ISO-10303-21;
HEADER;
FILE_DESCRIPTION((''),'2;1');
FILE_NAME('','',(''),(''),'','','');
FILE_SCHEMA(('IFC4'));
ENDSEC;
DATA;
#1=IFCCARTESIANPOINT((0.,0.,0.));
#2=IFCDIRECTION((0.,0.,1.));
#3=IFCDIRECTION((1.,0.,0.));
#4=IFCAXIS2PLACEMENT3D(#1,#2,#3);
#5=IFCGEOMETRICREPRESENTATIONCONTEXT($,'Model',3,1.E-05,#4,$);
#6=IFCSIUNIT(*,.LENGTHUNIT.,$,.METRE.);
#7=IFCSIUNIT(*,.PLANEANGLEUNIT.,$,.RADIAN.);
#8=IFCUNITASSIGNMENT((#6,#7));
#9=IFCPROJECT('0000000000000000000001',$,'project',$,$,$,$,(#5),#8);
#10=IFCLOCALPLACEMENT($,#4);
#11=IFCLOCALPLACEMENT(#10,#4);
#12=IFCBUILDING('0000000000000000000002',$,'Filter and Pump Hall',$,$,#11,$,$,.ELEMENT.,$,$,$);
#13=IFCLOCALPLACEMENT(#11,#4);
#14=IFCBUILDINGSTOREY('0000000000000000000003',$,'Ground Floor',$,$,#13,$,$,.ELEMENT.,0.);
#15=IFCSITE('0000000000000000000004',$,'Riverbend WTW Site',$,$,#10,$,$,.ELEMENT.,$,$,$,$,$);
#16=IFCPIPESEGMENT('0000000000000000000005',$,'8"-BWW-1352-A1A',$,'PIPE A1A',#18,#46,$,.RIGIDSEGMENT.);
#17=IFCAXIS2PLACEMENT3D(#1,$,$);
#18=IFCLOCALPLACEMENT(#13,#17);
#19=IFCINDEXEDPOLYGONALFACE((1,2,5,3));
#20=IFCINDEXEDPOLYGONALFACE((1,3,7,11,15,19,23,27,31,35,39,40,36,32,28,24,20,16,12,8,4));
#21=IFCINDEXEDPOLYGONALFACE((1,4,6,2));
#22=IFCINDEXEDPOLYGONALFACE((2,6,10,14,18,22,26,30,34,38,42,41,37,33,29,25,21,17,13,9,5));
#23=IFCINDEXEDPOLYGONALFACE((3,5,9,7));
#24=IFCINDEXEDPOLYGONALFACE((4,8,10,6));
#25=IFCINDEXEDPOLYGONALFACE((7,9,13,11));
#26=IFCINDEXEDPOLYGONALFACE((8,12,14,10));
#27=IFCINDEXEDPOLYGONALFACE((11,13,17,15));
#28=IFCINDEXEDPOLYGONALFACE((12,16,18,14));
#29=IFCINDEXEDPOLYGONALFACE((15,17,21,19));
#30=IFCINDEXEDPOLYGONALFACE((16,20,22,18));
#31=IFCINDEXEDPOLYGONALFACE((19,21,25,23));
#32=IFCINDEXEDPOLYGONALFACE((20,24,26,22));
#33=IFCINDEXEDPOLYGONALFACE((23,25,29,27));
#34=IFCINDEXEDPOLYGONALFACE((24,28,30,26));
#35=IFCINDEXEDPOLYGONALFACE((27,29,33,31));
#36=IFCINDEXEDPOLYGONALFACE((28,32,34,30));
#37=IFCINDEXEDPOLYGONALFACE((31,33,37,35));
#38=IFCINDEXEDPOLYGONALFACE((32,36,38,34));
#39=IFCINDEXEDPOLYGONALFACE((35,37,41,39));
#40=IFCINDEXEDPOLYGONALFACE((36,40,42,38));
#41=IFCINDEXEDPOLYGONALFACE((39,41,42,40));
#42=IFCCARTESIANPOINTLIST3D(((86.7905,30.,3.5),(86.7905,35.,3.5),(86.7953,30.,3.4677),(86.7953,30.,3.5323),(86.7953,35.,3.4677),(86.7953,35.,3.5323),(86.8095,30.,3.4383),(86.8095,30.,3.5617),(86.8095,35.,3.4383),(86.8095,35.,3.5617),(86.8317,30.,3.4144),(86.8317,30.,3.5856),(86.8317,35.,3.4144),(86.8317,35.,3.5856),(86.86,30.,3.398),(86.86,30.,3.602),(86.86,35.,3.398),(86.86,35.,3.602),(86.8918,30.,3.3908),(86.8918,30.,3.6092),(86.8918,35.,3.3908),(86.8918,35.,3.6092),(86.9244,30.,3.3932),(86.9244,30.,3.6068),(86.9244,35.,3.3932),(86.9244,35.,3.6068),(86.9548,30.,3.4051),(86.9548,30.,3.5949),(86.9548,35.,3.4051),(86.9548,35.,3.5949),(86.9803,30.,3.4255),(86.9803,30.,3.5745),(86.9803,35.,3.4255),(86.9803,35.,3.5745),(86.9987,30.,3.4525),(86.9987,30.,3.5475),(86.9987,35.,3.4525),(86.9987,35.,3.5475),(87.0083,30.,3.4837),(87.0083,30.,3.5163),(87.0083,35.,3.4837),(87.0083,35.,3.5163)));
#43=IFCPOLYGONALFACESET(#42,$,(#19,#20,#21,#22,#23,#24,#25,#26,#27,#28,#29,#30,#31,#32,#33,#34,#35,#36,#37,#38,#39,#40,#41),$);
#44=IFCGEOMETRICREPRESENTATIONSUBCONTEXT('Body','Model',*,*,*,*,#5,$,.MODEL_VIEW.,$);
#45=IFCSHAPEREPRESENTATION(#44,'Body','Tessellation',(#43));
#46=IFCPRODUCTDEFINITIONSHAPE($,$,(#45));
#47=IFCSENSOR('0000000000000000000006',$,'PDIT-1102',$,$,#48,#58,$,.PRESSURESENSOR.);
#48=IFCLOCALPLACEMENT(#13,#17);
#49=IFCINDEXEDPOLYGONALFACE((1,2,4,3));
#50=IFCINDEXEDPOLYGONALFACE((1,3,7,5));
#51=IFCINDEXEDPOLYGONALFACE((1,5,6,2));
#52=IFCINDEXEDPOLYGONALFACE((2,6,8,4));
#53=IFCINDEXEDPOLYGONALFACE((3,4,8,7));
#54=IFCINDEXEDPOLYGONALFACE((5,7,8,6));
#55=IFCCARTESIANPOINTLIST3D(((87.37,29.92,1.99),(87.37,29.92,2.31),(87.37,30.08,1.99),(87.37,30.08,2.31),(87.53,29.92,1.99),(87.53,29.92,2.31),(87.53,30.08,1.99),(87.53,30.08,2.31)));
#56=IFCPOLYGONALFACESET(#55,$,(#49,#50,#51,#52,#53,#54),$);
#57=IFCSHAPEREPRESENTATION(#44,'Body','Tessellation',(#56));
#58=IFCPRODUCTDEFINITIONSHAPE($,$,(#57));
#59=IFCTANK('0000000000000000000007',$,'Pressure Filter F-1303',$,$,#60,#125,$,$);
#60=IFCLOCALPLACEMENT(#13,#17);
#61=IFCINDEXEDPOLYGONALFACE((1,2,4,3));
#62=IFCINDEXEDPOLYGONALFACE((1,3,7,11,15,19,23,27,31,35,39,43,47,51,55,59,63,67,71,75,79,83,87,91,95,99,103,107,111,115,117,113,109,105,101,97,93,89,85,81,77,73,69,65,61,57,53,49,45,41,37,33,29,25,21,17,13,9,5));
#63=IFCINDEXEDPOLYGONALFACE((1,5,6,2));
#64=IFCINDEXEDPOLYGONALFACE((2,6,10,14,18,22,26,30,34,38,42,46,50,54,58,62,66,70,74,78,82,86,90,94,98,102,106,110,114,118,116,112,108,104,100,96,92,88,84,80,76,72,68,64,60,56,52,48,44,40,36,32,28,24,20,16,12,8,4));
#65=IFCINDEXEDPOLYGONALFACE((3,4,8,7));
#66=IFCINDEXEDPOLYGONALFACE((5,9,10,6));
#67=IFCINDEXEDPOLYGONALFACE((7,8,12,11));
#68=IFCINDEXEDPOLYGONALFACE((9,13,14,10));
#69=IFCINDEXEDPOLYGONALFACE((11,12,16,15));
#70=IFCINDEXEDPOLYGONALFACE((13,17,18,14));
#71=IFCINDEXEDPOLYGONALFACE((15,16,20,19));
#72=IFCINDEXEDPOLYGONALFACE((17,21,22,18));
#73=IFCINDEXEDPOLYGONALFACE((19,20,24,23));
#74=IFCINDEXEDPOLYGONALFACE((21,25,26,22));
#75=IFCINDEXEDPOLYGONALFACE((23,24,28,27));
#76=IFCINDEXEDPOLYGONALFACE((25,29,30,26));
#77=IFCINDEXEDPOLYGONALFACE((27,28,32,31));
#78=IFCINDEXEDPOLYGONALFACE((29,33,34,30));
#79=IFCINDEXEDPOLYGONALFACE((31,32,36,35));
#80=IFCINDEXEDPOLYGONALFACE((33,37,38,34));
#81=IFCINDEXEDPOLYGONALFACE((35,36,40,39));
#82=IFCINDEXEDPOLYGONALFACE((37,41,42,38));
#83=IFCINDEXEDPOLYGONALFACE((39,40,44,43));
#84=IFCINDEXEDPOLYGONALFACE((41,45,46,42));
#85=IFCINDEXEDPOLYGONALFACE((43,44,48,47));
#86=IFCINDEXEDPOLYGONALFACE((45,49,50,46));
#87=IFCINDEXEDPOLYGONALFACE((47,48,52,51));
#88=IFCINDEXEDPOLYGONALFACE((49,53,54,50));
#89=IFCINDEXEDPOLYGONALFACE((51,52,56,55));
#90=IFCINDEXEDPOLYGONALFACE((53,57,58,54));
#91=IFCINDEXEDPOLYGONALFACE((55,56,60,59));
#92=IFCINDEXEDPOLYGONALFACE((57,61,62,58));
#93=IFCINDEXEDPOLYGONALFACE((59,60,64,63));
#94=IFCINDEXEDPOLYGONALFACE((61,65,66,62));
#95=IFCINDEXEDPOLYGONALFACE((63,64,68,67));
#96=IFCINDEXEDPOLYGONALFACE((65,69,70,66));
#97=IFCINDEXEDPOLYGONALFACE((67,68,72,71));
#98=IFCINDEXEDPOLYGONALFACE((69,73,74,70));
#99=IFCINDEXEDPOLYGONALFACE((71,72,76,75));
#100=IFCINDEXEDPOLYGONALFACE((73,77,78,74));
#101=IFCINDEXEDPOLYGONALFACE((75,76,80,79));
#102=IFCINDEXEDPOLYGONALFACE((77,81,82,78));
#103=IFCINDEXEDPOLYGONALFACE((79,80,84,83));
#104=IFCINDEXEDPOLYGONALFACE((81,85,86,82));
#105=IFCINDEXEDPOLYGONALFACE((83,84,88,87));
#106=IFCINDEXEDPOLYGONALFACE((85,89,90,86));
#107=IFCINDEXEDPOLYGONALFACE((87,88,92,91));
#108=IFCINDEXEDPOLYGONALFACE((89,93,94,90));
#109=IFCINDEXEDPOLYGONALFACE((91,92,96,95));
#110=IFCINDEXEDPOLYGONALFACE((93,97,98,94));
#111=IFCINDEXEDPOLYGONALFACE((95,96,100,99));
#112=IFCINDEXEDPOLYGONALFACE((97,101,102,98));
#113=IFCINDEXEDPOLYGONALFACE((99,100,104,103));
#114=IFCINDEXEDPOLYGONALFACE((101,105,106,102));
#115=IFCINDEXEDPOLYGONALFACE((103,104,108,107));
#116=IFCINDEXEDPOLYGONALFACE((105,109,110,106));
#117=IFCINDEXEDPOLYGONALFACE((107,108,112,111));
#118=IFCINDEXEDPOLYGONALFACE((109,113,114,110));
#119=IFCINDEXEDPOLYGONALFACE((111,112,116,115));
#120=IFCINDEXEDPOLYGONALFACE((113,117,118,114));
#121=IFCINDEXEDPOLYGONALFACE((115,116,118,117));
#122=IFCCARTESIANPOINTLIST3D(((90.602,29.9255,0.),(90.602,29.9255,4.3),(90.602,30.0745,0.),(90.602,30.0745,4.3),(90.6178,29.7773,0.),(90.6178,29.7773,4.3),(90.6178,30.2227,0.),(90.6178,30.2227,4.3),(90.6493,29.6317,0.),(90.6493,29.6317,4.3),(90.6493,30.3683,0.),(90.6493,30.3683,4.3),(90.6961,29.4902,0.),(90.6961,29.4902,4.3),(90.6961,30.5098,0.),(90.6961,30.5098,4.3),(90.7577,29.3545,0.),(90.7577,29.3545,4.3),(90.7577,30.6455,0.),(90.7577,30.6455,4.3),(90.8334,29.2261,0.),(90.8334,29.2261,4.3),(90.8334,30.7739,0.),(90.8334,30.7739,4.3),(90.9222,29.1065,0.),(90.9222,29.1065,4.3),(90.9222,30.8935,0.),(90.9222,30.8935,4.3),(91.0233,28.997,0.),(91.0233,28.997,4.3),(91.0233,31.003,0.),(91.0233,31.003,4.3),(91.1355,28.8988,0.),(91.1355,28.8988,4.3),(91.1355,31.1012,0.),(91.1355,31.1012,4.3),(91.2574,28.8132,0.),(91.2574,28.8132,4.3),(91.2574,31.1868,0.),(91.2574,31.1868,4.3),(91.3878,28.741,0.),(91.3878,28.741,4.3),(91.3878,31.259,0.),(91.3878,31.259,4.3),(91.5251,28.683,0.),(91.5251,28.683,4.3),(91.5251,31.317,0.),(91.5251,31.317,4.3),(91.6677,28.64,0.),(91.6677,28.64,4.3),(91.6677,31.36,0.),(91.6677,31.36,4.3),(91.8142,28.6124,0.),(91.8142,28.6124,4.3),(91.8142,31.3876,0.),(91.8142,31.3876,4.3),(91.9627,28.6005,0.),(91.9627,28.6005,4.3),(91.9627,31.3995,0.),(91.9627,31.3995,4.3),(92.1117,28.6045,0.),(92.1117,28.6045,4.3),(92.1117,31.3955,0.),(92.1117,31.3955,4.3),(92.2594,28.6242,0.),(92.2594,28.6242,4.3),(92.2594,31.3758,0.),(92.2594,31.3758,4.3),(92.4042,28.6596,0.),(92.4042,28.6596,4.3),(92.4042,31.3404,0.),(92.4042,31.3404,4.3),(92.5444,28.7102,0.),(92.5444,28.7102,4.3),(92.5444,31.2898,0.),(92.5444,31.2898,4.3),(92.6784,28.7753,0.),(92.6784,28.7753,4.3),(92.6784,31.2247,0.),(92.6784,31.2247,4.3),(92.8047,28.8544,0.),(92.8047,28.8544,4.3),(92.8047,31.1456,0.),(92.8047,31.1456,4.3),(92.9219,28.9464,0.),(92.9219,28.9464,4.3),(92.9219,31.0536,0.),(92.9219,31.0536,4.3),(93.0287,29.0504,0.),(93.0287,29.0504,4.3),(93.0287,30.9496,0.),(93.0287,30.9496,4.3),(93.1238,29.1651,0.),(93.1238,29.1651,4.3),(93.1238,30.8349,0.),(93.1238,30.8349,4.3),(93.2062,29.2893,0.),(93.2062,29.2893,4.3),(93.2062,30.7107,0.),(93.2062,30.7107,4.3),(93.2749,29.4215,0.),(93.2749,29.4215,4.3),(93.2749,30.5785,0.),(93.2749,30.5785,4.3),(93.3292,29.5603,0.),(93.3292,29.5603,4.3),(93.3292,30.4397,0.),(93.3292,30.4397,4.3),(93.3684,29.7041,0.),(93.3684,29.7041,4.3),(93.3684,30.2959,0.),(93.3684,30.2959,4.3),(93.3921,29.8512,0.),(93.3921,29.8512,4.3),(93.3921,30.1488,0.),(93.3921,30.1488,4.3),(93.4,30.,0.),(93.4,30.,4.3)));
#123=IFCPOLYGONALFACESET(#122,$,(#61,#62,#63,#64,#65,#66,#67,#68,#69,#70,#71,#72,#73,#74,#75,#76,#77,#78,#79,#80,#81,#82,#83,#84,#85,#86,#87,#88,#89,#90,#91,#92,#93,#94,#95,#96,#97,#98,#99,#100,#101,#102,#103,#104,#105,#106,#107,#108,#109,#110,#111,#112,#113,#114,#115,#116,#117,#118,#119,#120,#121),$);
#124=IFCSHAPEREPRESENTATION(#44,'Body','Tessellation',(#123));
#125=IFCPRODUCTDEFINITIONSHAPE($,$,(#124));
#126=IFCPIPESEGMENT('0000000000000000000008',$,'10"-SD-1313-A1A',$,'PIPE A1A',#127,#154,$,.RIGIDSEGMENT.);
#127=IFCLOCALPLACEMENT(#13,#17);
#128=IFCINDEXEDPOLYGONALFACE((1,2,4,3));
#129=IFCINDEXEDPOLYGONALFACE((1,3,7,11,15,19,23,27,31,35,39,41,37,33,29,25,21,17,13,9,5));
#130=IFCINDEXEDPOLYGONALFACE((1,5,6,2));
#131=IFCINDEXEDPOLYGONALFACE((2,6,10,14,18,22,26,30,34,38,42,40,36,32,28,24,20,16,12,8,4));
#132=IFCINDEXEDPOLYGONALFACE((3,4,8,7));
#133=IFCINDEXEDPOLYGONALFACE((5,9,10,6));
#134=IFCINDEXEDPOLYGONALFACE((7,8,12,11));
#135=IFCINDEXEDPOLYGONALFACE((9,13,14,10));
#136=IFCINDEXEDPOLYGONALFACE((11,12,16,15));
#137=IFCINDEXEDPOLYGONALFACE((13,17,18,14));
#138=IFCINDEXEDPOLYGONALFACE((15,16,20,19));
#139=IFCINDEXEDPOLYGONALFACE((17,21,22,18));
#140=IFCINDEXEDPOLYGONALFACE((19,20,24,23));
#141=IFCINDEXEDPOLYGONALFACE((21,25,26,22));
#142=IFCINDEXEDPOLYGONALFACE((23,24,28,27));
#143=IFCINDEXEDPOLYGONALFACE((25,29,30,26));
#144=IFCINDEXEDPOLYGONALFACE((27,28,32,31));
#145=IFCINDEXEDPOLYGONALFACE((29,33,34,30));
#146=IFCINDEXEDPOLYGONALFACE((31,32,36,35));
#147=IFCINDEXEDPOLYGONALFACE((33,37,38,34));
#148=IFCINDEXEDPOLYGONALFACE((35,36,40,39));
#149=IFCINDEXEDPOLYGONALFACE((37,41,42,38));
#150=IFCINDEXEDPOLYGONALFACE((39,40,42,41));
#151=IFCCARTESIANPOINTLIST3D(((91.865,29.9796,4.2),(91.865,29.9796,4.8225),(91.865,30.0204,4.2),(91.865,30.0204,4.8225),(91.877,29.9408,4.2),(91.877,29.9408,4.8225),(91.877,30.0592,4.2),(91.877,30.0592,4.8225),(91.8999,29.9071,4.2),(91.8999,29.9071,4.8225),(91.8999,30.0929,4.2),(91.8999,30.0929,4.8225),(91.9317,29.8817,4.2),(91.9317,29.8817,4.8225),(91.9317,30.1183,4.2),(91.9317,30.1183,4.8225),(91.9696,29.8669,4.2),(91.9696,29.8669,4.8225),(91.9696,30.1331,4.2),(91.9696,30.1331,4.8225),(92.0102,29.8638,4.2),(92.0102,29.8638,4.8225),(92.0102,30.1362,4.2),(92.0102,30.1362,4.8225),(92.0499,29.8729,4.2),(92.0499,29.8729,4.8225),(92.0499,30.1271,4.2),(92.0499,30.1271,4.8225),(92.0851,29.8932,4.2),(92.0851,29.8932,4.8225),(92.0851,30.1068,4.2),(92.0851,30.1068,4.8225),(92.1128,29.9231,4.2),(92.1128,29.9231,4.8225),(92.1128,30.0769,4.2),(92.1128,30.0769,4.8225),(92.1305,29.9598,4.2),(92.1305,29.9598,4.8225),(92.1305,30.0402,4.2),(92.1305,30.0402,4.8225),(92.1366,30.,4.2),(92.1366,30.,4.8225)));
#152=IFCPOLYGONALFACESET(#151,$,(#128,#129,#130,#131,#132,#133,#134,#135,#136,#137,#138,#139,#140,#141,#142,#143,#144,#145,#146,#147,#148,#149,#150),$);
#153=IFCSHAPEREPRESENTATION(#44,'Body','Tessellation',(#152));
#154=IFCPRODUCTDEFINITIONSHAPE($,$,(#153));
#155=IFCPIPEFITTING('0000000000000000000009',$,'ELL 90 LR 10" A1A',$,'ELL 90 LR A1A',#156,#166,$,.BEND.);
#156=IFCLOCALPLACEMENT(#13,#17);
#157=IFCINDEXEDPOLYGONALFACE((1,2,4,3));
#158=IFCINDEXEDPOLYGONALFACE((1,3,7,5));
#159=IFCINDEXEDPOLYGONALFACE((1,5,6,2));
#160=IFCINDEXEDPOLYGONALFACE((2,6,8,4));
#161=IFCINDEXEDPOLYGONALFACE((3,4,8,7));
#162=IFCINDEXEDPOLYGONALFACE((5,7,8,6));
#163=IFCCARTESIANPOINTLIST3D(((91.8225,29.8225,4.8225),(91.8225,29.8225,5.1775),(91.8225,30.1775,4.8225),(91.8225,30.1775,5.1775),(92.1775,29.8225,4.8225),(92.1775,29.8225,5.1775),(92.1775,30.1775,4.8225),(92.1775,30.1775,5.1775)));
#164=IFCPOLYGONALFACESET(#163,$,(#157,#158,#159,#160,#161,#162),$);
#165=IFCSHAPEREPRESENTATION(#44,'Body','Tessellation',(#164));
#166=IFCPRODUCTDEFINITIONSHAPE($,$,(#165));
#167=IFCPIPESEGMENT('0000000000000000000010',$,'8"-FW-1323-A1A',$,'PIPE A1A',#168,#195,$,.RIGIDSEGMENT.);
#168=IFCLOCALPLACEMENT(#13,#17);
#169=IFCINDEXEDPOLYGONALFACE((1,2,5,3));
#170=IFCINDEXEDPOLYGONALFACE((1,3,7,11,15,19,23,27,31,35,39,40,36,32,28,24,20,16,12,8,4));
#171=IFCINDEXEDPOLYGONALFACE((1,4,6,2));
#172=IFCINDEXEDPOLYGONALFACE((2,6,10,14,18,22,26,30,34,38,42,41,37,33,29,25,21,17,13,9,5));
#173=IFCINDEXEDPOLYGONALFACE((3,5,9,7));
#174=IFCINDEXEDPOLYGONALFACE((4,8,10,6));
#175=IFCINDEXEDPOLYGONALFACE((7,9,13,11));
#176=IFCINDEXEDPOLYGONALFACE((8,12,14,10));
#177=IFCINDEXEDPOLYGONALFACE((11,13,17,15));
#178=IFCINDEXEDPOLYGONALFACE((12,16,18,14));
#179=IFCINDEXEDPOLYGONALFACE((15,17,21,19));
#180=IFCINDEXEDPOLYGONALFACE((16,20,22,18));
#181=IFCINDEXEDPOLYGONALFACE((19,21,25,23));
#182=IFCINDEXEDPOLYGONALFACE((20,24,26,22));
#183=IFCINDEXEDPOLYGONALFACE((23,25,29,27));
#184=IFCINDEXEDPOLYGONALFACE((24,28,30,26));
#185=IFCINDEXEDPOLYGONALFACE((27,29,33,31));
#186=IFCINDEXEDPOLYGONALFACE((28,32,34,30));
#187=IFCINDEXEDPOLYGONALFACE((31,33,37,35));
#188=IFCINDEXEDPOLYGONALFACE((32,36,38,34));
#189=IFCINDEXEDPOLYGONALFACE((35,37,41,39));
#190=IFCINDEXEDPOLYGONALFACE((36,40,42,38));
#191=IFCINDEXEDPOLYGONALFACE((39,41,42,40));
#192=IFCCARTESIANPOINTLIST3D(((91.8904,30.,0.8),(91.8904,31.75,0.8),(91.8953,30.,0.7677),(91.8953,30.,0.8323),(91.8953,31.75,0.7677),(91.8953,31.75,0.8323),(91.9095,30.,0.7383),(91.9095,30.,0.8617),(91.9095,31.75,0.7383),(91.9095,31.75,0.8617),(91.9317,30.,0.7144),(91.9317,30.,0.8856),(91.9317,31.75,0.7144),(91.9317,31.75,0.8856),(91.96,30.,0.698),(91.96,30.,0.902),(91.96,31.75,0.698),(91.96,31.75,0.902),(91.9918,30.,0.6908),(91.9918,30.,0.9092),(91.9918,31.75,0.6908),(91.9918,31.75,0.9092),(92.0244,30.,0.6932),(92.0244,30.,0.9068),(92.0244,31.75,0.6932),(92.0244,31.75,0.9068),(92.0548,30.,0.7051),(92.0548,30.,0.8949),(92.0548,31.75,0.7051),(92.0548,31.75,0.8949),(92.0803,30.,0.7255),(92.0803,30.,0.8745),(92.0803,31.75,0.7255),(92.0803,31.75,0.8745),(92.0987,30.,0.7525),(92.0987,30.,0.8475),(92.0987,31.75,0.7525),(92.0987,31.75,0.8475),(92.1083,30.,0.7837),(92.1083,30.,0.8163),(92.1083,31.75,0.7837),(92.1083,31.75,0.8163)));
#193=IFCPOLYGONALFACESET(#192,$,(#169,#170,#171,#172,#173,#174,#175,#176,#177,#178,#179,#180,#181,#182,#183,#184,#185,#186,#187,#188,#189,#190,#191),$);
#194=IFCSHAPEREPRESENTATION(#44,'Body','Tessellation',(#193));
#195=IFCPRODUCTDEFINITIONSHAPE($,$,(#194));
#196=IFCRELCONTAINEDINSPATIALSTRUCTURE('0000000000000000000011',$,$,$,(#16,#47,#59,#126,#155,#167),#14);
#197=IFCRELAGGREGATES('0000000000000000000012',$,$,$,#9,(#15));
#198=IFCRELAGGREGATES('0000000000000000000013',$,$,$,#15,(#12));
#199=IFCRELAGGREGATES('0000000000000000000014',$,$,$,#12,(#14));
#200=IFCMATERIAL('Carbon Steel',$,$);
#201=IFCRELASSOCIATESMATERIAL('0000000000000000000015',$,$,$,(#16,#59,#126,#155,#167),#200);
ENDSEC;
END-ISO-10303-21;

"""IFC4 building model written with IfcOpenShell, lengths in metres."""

from ifc_helpers import new_model, si_unit, frame, origin_with_axes, origin_2d, place, context, subcontext, project, spatial, rectangle, circle, extrude, material, element, save


model = new_model("IFC4")

# Units and contexts
model_context = context("Model", 3, precision=1e-05, world=origin_with_axes())
body_context = subcontext(model_context, "Body", "Model", "MODEL_VIEW")
ifc_project = project(units=[si_unit("LENGTHUNIT", "METRE"), si_unit("PLANEANGLEUNIT", "RADIAN")], contexts=[model_context])

# Site, building, storey
site_placement = place(None, origin_with_axes())
site = spatial("IfcSite", under=ifc_project, at=site_placement, Name="Riverbend WTW Site", CompositionType="ELEMENT")
building_placement = place(site_placement, origin_with_axes())
building = spatial("IfcBuilding", under=site, at=building_placement, Name="Filter and Pump Hall", CompositionType="ELEMENT")
storey_placement = place(building_placement, origin_with_axes())
storey = spatial("IfcBuildingStorey", under=building, at=storey_placement, Name="Ground Floor", CompositionType="ELEMENT", Elevation=0.0)

# Shared definitions
ifc_material_1 = material(Name="Carbon Steel")

# Pipe segment
pipe_segment_1_placement = place(None, frame((86.9, 30.0, 3.5), z_axis=(0.0, 0.0, 1.0), x_axis=(1.0, 0.0, 0.0)))
element("IfcPipeSegment", 1, at=pipe_segment_1_placement, inside=storey, material=ifc_material_1, Name="8\"-BWW-1352-A1A", ObjectType="PIPE A1A", PredefinedType="RIGIDSEGMENT", context=body_context, shape_type="SweptSolid", body=[
    extrude(circle(Radius=0.1095, at=origin_2d()), frame((0.0, 0.0, 0.0), z_axis=(0.0, 1.0, 0.0), x_axis=(-1.0, 0.0, 0.0)), (0.0, 0.0, 1.0), 5.0),
])

# Sensor
sensor_placement = place(None, frame((87.45, 30.0, 2.15), z_axis=(0.0, 0.0, 1.0), x_axis=(1.0, 0.0, 0.0)))
element("IfcSensor", 2, at=sensor_placement, inside=storey, Name="PDIT-1102", PredefinedType="PRESSURESENSOR", context=body_context, shape_type="SweptSolid", body=[
    extrude(rectangle(XDim=0.16, YDim=0.16, at=origin_2d()), frame((0.0, 0.0, -0.16), z_axis=(0.0, 0.0, 1.0), x_axis=(1.0, 0.0, 0.0)), (0.0, 0.0, 1.0), 0.32),
])

# Tank
tank_placement = place(None, frame((92.0, 30.0, 0.0), z_axis=(0.0, 0.0, 1.0), x_axis=(1.0, 0.0, 0.0)))
element("IfcTank", 3, at=tank_placement, inside=storey, material=ifc_material_1, Name="Pressure Filter F-1303", context=body_context, shape_type="SweptSolid", body=[
    extrude(circle(Radius=1.4, at=origin_2d()), origin_with_axes(), (0.0, 0.0, 1.0), 4.3),
])

# Pipe segment
pipe_segment_2_placement = place(None, frame((92.0, 30.0, 4.8225), z_axis=(0.0, 0.0, 1.0), x_axis=(1.0, 0.0, 0.0)))
element("IfcPipeSegment", 4, at=pipe_segment_2_placement, inside=storey, material=ifc_material_1, Name="10\"-SD-1313-A1A", ObjectType="PIPE A1A", PredefinedType="RIGIDSEGMENT", context=body_context, shape_type="SweptSolid", body=[
    extrude(circle(Radius=0.1366, at=origin_2d()), frame((0.0, 0.0, 0.0), z_axis=(0.0, 0.0, -1.0), x_axis=(1.0, 0.0, 0.0)), (0.0, 0.0, 1.0), 0.6225),
])

# Pipe fitting
pipe_fitting_1_placement = place(None, frame((92.0, 30.0, 5.0), z_axis=(0.0, 0.0, 1.0), x_axis=(1.0, 0.0, 0.0)))
element("IfcPipeFitting", 5, at=pipe_fitting_1_placement, inside=storey, material=ifc_material_1, Name="ELL 90 LR 10\" A1A", ObjectType="ELL 90 LR A1A", PredefinedType="BEND", context=body_context, shape_type="SweptSolid", body=[
    extrude(rectangle(XDim=0.355, YDim=0.355, at=origin_2d()), frame((0.0, 0.0, -0.1775), z_axis=(0.0, 0.0, 1.0), x_axis=(1.0, 0.0, 0.0)), (0.0, 0.0, 1.0), 0.355),
])

# Pipe segment
pipe_segment_3_placement = place(None, frame((92.0, 30.0, 0.8), z_axis=(0.0, 0.0, 1.0), x_axis=(1.0, 0.0, 0.0)))
element("IfcPipeSegment", 6, at=pipe_segment_3_placement, inside=storey, material=ifc_material_1, Name="8\"-FW-1323-A1A", ObjectType="PIPE A1A", PredefinedType="RIGIDSEGMENT", context=body_context, shape_type="SweptSolid", body=[
    extrude(circle(Radius=0.1095, at=origin_2d()), frame((0.0, 0.0, 0.0), z_axis=(0.0, 1.0, 0.0), x_axis=(-1.0, 0.0, 0.0)), (0.0, 0.0, 1.0), 1.75),
])

save(model, "model.ifc")
